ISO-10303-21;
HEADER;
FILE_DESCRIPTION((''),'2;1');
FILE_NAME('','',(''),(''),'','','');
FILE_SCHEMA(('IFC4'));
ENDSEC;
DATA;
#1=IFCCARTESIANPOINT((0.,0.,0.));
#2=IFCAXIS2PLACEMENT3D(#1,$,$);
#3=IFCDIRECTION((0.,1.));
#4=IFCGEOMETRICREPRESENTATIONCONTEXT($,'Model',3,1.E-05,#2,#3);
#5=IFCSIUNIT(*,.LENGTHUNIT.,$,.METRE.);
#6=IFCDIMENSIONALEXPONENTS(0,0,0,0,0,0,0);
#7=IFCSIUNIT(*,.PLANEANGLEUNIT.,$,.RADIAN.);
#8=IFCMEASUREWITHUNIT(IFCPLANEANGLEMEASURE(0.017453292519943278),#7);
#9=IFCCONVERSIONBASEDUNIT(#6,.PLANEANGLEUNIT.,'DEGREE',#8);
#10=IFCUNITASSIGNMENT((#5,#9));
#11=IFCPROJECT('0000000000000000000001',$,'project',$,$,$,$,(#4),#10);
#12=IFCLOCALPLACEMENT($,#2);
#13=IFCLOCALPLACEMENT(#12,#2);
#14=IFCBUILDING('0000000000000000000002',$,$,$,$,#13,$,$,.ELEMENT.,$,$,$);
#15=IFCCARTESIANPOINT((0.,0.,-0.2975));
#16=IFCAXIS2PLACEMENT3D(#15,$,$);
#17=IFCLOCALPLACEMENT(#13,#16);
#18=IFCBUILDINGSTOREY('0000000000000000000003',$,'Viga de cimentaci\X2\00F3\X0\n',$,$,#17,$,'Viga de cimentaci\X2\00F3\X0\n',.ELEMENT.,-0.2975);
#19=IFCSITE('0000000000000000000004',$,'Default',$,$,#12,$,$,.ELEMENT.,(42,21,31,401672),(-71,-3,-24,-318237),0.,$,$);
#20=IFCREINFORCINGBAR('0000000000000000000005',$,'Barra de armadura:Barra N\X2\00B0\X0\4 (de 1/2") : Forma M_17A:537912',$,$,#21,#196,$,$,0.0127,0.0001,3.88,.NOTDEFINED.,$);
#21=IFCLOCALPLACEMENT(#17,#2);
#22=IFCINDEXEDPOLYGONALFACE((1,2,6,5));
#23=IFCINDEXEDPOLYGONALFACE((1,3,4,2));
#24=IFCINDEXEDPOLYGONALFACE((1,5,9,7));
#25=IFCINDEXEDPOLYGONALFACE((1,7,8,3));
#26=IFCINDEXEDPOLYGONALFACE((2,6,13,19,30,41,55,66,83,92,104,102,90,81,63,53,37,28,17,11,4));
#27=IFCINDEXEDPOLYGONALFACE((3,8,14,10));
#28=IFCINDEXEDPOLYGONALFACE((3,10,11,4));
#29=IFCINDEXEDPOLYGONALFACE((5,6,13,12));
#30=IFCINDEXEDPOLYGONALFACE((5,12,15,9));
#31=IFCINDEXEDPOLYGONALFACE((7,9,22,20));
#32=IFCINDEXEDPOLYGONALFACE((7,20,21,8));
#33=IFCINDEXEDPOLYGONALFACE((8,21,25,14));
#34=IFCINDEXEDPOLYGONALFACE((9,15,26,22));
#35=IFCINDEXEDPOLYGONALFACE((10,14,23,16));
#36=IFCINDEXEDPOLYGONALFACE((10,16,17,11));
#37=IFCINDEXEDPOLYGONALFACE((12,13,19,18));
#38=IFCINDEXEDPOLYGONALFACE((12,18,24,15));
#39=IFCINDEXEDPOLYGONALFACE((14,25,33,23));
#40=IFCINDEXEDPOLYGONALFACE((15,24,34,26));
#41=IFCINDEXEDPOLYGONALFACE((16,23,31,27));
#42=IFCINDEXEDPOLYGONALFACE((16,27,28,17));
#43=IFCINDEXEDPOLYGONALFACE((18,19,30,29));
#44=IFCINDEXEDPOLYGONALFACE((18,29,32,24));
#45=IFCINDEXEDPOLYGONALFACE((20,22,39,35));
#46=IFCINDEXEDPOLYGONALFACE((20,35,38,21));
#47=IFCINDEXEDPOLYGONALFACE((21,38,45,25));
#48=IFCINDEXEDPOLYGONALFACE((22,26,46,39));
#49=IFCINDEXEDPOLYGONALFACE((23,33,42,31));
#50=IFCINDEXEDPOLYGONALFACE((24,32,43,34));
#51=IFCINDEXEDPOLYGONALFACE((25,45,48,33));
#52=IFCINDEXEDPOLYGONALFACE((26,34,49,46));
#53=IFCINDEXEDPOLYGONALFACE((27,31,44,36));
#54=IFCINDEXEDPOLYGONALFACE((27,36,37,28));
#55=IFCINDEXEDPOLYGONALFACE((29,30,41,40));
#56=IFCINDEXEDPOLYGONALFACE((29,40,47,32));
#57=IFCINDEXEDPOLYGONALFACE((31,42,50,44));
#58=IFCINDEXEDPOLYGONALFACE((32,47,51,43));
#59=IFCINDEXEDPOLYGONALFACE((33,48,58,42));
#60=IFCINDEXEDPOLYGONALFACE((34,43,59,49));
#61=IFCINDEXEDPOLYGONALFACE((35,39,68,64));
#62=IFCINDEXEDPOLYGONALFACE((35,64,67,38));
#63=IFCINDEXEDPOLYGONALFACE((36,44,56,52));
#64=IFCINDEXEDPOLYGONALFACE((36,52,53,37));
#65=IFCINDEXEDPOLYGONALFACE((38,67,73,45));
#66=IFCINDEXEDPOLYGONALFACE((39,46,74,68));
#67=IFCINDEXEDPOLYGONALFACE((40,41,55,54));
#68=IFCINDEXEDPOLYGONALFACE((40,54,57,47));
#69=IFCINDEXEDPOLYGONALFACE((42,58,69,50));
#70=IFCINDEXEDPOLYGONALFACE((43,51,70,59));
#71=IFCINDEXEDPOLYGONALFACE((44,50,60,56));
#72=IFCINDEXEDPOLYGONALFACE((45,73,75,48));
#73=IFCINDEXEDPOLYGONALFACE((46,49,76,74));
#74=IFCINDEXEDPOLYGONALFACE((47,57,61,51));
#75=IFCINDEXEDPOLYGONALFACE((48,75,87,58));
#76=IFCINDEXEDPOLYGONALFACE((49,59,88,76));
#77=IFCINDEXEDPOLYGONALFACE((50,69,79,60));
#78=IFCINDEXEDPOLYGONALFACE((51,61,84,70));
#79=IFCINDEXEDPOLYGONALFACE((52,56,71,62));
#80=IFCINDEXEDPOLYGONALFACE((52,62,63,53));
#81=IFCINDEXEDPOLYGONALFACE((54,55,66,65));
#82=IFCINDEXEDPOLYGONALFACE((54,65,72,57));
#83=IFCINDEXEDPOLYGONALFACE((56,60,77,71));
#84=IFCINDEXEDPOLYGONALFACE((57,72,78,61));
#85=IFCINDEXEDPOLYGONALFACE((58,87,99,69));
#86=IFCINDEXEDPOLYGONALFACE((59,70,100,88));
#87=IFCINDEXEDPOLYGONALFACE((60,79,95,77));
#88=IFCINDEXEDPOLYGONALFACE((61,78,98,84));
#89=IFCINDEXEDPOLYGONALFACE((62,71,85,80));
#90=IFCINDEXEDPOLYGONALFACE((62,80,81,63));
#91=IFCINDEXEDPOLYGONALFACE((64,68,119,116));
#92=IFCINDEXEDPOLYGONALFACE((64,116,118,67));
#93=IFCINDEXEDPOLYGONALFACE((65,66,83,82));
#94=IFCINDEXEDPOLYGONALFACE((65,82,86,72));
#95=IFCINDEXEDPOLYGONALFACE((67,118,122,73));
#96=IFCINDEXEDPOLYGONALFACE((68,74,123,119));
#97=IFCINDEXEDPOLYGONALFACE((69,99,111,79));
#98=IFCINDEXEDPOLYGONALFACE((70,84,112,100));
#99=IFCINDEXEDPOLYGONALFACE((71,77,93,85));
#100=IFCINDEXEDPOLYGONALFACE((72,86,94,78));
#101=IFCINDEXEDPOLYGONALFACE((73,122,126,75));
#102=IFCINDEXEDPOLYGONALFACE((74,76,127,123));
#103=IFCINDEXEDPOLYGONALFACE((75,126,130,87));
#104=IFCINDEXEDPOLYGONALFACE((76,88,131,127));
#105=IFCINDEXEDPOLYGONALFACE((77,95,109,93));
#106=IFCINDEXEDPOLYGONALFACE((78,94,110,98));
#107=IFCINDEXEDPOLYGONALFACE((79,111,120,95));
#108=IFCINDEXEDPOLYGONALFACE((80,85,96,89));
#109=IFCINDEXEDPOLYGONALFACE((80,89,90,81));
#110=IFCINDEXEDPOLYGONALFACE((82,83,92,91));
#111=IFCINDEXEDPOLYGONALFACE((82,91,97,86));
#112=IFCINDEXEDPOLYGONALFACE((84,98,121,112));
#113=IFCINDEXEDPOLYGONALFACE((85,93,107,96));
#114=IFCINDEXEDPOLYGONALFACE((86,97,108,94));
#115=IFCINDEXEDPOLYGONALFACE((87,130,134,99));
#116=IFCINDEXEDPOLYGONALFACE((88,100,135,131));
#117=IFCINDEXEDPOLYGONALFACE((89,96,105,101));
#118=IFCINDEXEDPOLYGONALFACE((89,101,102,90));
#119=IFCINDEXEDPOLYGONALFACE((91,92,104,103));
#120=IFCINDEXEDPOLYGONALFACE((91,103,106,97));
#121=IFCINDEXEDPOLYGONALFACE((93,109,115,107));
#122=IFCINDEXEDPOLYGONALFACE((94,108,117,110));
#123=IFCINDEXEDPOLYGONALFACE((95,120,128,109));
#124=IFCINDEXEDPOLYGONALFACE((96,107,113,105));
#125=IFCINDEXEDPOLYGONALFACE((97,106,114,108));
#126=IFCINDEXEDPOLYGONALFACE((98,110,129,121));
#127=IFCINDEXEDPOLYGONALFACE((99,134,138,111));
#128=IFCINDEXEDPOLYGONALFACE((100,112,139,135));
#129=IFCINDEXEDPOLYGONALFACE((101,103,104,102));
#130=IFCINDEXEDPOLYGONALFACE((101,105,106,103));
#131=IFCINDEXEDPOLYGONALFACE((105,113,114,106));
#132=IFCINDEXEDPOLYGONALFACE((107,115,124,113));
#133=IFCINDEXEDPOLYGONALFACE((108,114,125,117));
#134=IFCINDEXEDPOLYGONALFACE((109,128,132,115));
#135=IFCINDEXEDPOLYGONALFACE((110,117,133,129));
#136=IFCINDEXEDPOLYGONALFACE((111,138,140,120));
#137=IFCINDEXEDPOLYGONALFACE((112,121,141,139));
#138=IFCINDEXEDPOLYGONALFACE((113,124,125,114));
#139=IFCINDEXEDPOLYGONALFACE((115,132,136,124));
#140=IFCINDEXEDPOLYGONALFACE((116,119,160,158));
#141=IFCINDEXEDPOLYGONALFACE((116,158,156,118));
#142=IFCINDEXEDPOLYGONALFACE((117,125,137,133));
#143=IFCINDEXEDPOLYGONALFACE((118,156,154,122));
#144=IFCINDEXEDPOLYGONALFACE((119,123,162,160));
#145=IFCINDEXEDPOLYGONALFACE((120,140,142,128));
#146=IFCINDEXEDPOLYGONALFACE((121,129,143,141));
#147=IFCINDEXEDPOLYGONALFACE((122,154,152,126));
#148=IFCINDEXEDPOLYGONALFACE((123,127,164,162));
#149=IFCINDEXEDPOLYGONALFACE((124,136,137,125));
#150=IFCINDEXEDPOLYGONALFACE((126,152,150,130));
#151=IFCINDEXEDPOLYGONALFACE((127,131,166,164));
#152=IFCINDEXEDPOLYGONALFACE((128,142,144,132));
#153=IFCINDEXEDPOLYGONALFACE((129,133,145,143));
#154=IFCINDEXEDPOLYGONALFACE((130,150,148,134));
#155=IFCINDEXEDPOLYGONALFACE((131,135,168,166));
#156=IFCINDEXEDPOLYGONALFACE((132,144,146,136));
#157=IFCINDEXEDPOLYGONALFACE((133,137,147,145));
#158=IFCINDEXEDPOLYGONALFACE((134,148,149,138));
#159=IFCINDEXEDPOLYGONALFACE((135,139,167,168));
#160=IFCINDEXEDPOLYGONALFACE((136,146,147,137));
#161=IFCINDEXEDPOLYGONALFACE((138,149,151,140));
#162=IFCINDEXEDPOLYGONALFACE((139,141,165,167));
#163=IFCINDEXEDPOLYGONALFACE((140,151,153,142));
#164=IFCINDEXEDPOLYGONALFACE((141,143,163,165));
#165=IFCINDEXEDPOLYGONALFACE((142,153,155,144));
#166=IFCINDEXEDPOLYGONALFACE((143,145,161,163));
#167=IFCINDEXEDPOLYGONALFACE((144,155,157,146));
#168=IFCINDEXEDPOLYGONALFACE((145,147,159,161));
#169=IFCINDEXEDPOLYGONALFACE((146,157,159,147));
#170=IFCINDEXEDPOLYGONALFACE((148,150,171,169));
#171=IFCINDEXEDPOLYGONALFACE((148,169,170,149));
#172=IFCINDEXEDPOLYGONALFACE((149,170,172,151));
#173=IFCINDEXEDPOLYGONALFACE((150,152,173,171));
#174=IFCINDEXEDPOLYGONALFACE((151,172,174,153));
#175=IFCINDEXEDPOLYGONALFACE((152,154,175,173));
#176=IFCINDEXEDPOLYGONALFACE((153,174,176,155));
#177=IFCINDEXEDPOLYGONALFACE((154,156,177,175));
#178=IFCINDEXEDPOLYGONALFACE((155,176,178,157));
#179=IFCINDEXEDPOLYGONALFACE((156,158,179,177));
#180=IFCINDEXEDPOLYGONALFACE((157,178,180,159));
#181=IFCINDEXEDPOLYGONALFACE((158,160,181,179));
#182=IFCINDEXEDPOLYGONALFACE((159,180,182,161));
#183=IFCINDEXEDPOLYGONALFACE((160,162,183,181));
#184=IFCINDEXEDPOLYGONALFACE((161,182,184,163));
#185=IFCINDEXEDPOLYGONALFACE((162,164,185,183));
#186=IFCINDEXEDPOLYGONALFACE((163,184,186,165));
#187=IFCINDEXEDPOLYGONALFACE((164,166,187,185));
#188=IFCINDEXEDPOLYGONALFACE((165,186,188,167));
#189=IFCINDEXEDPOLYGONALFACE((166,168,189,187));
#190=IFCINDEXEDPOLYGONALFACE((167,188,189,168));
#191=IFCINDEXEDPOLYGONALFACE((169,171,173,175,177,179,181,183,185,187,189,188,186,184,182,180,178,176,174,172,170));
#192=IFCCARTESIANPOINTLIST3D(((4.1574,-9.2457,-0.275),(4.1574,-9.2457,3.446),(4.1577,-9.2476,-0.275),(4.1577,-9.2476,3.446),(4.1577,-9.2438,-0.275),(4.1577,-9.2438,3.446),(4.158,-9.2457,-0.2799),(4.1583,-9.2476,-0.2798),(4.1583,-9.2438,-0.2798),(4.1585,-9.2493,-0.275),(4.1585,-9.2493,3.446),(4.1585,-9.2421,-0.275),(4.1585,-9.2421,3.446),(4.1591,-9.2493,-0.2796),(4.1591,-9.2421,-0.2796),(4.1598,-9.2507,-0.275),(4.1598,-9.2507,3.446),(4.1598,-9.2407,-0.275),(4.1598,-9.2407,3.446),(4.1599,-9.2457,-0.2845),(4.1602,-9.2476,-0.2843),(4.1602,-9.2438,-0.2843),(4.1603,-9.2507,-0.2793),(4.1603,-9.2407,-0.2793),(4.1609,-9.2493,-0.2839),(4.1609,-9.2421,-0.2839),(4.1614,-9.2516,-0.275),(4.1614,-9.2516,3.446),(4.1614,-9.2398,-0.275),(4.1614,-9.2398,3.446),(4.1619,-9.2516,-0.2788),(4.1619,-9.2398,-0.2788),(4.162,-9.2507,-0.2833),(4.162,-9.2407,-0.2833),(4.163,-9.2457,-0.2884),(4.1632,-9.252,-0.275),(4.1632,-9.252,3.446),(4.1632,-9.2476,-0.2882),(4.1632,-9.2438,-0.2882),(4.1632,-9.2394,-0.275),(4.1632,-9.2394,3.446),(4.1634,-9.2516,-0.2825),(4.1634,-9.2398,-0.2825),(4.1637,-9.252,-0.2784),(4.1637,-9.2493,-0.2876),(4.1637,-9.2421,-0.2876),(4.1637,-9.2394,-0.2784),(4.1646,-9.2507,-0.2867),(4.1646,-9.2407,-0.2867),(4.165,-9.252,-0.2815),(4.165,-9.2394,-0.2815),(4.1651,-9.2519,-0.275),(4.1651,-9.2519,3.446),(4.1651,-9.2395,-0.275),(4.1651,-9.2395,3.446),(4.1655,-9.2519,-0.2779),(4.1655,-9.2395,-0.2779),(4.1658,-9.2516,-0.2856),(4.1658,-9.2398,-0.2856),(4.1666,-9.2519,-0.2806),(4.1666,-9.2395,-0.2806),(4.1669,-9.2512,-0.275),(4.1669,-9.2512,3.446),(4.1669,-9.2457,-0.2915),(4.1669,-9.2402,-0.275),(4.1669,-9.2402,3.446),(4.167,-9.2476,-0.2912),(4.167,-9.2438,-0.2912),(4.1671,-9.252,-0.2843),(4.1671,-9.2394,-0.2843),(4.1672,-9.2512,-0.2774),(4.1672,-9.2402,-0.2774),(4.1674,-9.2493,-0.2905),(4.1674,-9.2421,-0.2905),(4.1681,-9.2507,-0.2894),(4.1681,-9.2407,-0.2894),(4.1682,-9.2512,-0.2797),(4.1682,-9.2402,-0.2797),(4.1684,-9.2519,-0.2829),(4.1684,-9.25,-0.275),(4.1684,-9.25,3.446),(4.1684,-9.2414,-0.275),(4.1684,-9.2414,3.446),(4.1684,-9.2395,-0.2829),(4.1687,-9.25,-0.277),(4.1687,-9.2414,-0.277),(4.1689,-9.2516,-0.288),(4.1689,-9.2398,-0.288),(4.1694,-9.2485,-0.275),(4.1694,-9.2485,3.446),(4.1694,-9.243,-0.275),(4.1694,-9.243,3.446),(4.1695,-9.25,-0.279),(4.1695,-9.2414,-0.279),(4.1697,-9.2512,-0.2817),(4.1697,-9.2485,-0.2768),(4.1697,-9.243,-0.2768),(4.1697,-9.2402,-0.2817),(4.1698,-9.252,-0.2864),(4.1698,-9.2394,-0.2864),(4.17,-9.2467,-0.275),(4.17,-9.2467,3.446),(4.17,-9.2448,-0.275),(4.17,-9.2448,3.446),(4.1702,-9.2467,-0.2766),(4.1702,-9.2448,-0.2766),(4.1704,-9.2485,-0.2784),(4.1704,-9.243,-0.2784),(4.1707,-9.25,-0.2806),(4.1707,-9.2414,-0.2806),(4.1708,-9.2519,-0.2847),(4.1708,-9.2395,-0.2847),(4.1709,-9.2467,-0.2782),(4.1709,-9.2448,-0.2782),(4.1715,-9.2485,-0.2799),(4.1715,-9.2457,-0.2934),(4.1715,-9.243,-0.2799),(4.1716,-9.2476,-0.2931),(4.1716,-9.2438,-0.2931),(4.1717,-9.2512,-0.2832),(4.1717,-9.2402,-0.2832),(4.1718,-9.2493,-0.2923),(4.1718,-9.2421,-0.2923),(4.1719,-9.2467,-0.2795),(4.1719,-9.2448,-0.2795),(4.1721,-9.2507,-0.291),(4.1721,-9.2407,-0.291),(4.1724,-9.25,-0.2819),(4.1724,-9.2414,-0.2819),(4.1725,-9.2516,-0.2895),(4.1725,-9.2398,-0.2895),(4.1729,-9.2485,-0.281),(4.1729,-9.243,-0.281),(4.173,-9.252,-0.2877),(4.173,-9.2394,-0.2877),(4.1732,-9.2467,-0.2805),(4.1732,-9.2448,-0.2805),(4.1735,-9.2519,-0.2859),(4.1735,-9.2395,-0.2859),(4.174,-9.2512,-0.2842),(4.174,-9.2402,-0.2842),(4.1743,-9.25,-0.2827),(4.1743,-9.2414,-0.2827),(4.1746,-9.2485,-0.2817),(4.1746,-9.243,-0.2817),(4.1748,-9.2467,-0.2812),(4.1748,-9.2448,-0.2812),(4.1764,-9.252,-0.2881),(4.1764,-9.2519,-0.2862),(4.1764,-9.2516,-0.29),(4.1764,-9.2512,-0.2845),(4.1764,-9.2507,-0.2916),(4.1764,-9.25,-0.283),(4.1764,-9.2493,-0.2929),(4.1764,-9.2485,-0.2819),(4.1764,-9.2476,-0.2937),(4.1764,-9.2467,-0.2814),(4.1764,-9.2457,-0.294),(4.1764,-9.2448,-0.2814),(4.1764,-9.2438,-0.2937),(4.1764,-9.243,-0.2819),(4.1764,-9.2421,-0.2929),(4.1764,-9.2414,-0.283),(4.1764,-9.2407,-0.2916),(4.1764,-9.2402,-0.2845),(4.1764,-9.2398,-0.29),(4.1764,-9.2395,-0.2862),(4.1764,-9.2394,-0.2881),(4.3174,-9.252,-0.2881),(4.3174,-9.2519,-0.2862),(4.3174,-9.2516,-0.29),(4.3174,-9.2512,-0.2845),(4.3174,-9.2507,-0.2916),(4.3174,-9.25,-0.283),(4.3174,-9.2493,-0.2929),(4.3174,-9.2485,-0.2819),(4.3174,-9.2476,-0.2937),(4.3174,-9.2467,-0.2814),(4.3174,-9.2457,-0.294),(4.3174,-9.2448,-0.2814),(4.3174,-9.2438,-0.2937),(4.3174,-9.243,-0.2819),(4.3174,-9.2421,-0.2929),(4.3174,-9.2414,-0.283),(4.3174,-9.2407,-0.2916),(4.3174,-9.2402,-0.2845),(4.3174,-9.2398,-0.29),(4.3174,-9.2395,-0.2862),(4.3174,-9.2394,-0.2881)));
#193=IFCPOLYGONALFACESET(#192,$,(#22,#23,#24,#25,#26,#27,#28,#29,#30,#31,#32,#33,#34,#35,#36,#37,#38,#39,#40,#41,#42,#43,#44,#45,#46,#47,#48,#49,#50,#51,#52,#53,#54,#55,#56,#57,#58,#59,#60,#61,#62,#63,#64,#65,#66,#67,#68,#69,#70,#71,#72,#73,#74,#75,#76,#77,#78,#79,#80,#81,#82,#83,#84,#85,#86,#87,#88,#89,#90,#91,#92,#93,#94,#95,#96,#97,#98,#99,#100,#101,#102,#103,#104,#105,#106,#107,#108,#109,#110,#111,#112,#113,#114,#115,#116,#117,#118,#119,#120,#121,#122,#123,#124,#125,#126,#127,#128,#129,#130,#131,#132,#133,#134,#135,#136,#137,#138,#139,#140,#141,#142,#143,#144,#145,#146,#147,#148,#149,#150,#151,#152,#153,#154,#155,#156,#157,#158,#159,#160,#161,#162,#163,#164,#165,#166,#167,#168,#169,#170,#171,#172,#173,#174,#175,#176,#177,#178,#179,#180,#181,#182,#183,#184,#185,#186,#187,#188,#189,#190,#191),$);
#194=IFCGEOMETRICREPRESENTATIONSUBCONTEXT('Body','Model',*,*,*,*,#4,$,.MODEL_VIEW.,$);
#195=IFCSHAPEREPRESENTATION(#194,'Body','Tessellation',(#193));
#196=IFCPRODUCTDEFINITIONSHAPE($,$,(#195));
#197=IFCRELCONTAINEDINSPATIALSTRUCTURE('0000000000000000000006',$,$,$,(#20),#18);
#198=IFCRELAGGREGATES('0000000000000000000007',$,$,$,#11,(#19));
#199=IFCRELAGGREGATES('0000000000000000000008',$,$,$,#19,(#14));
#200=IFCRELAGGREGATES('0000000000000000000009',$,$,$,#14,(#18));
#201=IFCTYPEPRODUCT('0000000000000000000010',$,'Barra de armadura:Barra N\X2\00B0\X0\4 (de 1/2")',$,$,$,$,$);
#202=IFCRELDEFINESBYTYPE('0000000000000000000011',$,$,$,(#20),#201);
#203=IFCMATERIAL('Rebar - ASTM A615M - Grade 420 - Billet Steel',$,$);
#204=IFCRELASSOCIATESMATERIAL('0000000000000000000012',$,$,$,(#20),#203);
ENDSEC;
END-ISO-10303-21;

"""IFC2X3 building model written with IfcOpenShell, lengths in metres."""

from ifc_helpers import new_model, entity, si_unit, converted_unit, direction, frame, origin, place, context, subcontext, project, spatial, material, type_object, element, save


model = new_model("IFC2X3")

# Units and contexts
model_context = context("Model", 3, precision=1e-05, world=origin(), true_north=direction((0.0, 1.0)))
body_context = subcontext(model_context, "Body", "Model", "MODEL_VIEW")
ifc_project = project(units=[si_unit("LENGTHUNIT", "METRE"), converted_unit("PLANEANGLEUNIT", "DEGREE", entity("IfcPlaneAngleMeasure", 0.017453292519943278), si_unit("PLANEANGLEUNIT", "RADIAN"), dimensions=[0, 0, 0, 0, 0, 0, 0])], contexts=[model_context])

# Site, building, storey
site_placement = place(None, origin())
site = spatial("IfcSite", under=ifc_project, at=site_placement, Name="Default", CompositionType="ELEMENT", RefLatitude=(42, 21, 31, 401672), RefLongitude=(-71, -3, -24, -318237), RefElevation=0.0)
building_placement = place(site_placement, origin())
building = spatial("IfcBuilding", under=site, at=building_placement, CompositionType="ELEMENT")
storey_placement = place(building_placement, frame((0.0, 0.0, -0.2975)))
storey = spatial("IfcBuildingStorey", under=building, at=storey_placement, Name="Viga de cimentación", LongName="Viga de cimentación", CompositionType="ELEMENT", Elevation=-0.2975)

# Reinforcing bar
ifc_material_1 = material(Name="Rebar - ASTM A615M - Grade 420 - Billet Steel")
type_product_1 = type_object("IfcTypeProduct", Name="Barra de armadura:Barra N°4 (de 1/2\")")
reinforcing_bar_1_placement = place(storey_placement, origin())
element("IfcReinforcingBar", 1, at=reinforcing_bar_1_placement, inside=storey, type_object=type_product_1, material=ifc_material_1, Name="Barra de armadura:Barra N°4 (de 1/2\") : Forma M_17A:537912", BarLength=3.88, BarRole="NOTDEFINED", CrossSectionArea=0.0001, NominalDiameter=0.0127, context=body_context, shape_type="AdvancedSweptSolid", body=[
    entity("IfcSweptDiskSolid", entity("IfcCompositeCurve", [entity("IfcCompositeCurveSegment", "CONTINUOUS", True, entity("IfcPolyline", [entity("IfcCartesianPoint", [4.1637, -9.2457, 3.446]), entity("IfcCartesianPoint", [4.1637, -9.2457, -0.275])])), entity("IfcCompositeCurveSegment", "CONTINUOUS", True, entity("IfcTrimmedCurve", entity("IfcCircle", entity("IfcAxis2Placement3D", entity("IfcCartesianPoint", [4.1764, -9.2457, -0.275]), entity("IfcDirection", [0.0, -1.0, 0.0]), entity("IfcDirection", [0.0, 0.0, -1.0])), 0.0127), [entity("IfcParameterValue", 270.0)], [entity("IfcParameterValue", 360.0)], True, "PARAMETER")), entity("IfcCompositeCurveSegment", "CONTINUOUS", True, entity("IfcPolyline", [entity("IfcCartesianPoint", [4.1764, -9.2457, -0.2877]), entity("IfcCartesianPoint", [4.3174, -9.2457, -0.2877])]))], False), 0.0063, None, 0.0, 92.0),
])

save(model, "model.ifc")
